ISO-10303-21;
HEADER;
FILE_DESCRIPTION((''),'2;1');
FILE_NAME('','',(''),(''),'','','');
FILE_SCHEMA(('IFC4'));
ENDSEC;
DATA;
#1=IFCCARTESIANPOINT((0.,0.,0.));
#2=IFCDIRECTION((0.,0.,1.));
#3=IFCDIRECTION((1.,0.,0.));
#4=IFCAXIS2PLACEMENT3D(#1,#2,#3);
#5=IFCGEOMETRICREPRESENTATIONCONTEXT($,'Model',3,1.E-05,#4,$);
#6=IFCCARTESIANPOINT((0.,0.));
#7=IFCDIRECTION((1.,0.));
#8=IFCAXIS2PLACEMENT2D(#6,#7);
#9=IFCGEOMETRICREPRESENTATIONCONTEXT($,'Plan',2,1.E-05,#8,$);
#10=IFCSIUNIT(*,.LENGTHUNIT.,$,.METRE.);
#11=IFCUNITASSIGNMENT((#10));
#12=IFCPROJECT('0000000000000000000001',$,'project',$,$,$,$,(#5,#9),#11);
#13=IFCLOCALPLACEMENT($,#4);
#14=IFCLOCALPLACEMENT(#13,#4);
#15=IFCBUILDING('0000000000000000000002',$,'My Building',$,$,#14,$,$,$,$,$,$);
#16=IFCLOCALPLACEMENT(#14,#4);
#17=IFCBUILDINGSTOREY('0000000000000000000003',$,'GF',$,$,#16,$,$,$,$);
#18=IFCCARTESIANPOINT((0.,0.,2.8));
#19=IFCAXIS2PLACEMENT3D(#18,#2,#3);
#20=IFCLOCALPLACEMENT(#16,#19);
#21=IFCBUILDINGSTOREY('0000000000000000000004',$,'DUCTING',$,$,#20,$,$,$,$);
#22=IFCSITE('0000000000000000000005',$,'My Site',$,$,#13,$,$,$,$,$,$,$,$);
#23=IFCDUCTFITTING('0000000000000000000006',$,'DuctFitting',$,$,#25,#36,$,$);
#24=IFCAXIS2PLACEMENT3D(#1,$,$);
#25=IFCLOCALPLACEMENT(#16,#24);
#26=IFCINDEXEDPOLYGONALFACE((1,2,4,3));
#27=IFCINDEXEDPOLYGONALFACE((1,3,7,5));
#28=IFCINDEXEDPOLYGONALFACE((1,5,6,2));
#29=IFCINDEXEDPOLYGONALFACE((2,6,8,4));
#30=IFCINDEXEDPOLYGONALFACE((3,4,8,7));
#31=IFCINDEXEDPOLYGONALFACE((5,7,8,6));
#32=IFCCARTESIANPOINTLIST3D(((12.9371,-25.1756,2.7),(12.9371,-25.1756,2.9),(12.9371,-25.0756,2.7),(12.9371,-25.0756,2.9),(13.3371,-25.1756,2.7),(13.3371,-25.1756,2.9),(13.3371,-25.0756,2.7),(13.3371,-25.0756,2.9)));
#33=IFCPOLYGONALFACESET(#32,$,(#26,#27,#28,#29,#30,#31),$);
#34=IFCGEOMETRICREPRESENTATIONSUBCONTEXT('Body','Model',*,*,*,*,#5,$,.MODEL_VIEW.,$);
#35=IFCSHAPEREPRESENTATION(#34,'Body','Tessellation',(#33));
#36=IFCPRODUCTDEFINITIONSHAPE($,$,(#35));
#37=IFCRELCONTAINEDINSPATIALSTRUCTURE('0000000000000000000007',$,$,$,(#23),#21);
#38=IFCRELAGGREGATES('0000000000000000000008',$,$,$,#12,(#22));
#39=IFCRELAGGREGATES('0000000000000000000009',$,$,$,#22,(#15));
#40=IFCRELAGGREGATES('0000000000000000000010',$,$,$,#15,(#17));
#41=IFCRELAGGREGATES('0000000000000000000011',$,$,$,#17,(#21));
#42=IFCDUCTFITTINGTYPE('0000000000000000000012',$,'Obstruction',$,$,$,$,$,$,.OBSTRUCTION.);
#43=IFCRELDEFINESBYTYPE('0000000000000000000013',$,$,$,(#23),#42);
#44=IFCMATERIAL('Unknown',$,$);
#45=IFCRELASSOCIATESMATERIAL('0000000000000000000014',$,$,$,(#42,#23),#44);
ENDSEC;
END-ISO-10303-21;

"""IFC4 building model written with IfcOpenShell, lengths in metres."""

from ifc_helpers import new_model, si_unit, frame, origin_with_axes, origin_2d_with_axis, place, context, subcontext, project, spatial, rectangle, extrude, material, material_profile, profile_set, profile_usage, type_object, element, save


model = new_model("IFC4")

# Units and contexts
model_context = context("Model", 3, precision=1e-05, world=origin_with_axes())
plan_context = context("Plan", 2, precision=1e-05, world=origin_2d_with_axis())
body_context = subcontext(model_context, "Body", "Model", "MODEL_VIEW")
ifc_project = project(units=[si_unit("LENGTHUNIT", "METRE")], contexts=[model_context, plan_context])

# Site, building, storeys
site_placement = place(None, origin_with_axes())
site = spatial("IfcSite", under=ifc_project, at=site_placement, Name="My Site")
building_placement = place(site_placement, origin_with_axes())
building = spatial("IfcBuilding", under=site, at=building_placement, Name="My Building")
storey_1_placement = place(building_placement, origin_with_axes())
storey_1 = spatial("IfcBuildingStorey", under=building, at=storey_1_placement, Name="GF")
storey_2_placement = place(storey_1_placement, frame((0.0, 0.0, 2.8), z_axis=(0.0, 0.0, 1.0), x_axis=(1.0, 0.0, 0.0)))
storey_2 = spatial("IfcBuildingStorey", under=storey_1, at=storey_2_placement, Name="DUCTING")

# Shared definitions
ifc_material = material(Name="Unknown")

# Duct fitting
ifc_material_profile_1 = material_profile(ifc_material, rectangle(XDim=0.4, YDim=0.2))
ifc_profile_set_1 = profile_set([ifc_material_profile_1])
duct_fitting_type_1 = type_object("IfcDuctFittingType", Name="Obstruction", PredefinedType="OBSTRUCTION", material=ifc_profile_set_1)
ifc_profile_usage_1 = profile_usage(ifc_profile_set_1, cardinal=5)
duct_fitting_1_placement = place(storey_2_placement, frame((13.1371, -25.1756, 0.0), z_axis=(0.0, 1.0, 0.0), x_axis=(-1.0, 0.0, 0.0)))
element("IfcDuctFitting", 1, at=duct_fitting_1_placement, inside=storey_2, type_object=duct_fitting_type_1, material=ifc_profile_usage_1, Name="DuctFitting", context=body_context, shape_type="SweptSolid", body=[
    extrude(rectangle(XDim=0.4, YDim=0.2), origin_with_axes(), (0.0, 0.0, 1.0), 0.1),
])

save(model, "model.ifc")
